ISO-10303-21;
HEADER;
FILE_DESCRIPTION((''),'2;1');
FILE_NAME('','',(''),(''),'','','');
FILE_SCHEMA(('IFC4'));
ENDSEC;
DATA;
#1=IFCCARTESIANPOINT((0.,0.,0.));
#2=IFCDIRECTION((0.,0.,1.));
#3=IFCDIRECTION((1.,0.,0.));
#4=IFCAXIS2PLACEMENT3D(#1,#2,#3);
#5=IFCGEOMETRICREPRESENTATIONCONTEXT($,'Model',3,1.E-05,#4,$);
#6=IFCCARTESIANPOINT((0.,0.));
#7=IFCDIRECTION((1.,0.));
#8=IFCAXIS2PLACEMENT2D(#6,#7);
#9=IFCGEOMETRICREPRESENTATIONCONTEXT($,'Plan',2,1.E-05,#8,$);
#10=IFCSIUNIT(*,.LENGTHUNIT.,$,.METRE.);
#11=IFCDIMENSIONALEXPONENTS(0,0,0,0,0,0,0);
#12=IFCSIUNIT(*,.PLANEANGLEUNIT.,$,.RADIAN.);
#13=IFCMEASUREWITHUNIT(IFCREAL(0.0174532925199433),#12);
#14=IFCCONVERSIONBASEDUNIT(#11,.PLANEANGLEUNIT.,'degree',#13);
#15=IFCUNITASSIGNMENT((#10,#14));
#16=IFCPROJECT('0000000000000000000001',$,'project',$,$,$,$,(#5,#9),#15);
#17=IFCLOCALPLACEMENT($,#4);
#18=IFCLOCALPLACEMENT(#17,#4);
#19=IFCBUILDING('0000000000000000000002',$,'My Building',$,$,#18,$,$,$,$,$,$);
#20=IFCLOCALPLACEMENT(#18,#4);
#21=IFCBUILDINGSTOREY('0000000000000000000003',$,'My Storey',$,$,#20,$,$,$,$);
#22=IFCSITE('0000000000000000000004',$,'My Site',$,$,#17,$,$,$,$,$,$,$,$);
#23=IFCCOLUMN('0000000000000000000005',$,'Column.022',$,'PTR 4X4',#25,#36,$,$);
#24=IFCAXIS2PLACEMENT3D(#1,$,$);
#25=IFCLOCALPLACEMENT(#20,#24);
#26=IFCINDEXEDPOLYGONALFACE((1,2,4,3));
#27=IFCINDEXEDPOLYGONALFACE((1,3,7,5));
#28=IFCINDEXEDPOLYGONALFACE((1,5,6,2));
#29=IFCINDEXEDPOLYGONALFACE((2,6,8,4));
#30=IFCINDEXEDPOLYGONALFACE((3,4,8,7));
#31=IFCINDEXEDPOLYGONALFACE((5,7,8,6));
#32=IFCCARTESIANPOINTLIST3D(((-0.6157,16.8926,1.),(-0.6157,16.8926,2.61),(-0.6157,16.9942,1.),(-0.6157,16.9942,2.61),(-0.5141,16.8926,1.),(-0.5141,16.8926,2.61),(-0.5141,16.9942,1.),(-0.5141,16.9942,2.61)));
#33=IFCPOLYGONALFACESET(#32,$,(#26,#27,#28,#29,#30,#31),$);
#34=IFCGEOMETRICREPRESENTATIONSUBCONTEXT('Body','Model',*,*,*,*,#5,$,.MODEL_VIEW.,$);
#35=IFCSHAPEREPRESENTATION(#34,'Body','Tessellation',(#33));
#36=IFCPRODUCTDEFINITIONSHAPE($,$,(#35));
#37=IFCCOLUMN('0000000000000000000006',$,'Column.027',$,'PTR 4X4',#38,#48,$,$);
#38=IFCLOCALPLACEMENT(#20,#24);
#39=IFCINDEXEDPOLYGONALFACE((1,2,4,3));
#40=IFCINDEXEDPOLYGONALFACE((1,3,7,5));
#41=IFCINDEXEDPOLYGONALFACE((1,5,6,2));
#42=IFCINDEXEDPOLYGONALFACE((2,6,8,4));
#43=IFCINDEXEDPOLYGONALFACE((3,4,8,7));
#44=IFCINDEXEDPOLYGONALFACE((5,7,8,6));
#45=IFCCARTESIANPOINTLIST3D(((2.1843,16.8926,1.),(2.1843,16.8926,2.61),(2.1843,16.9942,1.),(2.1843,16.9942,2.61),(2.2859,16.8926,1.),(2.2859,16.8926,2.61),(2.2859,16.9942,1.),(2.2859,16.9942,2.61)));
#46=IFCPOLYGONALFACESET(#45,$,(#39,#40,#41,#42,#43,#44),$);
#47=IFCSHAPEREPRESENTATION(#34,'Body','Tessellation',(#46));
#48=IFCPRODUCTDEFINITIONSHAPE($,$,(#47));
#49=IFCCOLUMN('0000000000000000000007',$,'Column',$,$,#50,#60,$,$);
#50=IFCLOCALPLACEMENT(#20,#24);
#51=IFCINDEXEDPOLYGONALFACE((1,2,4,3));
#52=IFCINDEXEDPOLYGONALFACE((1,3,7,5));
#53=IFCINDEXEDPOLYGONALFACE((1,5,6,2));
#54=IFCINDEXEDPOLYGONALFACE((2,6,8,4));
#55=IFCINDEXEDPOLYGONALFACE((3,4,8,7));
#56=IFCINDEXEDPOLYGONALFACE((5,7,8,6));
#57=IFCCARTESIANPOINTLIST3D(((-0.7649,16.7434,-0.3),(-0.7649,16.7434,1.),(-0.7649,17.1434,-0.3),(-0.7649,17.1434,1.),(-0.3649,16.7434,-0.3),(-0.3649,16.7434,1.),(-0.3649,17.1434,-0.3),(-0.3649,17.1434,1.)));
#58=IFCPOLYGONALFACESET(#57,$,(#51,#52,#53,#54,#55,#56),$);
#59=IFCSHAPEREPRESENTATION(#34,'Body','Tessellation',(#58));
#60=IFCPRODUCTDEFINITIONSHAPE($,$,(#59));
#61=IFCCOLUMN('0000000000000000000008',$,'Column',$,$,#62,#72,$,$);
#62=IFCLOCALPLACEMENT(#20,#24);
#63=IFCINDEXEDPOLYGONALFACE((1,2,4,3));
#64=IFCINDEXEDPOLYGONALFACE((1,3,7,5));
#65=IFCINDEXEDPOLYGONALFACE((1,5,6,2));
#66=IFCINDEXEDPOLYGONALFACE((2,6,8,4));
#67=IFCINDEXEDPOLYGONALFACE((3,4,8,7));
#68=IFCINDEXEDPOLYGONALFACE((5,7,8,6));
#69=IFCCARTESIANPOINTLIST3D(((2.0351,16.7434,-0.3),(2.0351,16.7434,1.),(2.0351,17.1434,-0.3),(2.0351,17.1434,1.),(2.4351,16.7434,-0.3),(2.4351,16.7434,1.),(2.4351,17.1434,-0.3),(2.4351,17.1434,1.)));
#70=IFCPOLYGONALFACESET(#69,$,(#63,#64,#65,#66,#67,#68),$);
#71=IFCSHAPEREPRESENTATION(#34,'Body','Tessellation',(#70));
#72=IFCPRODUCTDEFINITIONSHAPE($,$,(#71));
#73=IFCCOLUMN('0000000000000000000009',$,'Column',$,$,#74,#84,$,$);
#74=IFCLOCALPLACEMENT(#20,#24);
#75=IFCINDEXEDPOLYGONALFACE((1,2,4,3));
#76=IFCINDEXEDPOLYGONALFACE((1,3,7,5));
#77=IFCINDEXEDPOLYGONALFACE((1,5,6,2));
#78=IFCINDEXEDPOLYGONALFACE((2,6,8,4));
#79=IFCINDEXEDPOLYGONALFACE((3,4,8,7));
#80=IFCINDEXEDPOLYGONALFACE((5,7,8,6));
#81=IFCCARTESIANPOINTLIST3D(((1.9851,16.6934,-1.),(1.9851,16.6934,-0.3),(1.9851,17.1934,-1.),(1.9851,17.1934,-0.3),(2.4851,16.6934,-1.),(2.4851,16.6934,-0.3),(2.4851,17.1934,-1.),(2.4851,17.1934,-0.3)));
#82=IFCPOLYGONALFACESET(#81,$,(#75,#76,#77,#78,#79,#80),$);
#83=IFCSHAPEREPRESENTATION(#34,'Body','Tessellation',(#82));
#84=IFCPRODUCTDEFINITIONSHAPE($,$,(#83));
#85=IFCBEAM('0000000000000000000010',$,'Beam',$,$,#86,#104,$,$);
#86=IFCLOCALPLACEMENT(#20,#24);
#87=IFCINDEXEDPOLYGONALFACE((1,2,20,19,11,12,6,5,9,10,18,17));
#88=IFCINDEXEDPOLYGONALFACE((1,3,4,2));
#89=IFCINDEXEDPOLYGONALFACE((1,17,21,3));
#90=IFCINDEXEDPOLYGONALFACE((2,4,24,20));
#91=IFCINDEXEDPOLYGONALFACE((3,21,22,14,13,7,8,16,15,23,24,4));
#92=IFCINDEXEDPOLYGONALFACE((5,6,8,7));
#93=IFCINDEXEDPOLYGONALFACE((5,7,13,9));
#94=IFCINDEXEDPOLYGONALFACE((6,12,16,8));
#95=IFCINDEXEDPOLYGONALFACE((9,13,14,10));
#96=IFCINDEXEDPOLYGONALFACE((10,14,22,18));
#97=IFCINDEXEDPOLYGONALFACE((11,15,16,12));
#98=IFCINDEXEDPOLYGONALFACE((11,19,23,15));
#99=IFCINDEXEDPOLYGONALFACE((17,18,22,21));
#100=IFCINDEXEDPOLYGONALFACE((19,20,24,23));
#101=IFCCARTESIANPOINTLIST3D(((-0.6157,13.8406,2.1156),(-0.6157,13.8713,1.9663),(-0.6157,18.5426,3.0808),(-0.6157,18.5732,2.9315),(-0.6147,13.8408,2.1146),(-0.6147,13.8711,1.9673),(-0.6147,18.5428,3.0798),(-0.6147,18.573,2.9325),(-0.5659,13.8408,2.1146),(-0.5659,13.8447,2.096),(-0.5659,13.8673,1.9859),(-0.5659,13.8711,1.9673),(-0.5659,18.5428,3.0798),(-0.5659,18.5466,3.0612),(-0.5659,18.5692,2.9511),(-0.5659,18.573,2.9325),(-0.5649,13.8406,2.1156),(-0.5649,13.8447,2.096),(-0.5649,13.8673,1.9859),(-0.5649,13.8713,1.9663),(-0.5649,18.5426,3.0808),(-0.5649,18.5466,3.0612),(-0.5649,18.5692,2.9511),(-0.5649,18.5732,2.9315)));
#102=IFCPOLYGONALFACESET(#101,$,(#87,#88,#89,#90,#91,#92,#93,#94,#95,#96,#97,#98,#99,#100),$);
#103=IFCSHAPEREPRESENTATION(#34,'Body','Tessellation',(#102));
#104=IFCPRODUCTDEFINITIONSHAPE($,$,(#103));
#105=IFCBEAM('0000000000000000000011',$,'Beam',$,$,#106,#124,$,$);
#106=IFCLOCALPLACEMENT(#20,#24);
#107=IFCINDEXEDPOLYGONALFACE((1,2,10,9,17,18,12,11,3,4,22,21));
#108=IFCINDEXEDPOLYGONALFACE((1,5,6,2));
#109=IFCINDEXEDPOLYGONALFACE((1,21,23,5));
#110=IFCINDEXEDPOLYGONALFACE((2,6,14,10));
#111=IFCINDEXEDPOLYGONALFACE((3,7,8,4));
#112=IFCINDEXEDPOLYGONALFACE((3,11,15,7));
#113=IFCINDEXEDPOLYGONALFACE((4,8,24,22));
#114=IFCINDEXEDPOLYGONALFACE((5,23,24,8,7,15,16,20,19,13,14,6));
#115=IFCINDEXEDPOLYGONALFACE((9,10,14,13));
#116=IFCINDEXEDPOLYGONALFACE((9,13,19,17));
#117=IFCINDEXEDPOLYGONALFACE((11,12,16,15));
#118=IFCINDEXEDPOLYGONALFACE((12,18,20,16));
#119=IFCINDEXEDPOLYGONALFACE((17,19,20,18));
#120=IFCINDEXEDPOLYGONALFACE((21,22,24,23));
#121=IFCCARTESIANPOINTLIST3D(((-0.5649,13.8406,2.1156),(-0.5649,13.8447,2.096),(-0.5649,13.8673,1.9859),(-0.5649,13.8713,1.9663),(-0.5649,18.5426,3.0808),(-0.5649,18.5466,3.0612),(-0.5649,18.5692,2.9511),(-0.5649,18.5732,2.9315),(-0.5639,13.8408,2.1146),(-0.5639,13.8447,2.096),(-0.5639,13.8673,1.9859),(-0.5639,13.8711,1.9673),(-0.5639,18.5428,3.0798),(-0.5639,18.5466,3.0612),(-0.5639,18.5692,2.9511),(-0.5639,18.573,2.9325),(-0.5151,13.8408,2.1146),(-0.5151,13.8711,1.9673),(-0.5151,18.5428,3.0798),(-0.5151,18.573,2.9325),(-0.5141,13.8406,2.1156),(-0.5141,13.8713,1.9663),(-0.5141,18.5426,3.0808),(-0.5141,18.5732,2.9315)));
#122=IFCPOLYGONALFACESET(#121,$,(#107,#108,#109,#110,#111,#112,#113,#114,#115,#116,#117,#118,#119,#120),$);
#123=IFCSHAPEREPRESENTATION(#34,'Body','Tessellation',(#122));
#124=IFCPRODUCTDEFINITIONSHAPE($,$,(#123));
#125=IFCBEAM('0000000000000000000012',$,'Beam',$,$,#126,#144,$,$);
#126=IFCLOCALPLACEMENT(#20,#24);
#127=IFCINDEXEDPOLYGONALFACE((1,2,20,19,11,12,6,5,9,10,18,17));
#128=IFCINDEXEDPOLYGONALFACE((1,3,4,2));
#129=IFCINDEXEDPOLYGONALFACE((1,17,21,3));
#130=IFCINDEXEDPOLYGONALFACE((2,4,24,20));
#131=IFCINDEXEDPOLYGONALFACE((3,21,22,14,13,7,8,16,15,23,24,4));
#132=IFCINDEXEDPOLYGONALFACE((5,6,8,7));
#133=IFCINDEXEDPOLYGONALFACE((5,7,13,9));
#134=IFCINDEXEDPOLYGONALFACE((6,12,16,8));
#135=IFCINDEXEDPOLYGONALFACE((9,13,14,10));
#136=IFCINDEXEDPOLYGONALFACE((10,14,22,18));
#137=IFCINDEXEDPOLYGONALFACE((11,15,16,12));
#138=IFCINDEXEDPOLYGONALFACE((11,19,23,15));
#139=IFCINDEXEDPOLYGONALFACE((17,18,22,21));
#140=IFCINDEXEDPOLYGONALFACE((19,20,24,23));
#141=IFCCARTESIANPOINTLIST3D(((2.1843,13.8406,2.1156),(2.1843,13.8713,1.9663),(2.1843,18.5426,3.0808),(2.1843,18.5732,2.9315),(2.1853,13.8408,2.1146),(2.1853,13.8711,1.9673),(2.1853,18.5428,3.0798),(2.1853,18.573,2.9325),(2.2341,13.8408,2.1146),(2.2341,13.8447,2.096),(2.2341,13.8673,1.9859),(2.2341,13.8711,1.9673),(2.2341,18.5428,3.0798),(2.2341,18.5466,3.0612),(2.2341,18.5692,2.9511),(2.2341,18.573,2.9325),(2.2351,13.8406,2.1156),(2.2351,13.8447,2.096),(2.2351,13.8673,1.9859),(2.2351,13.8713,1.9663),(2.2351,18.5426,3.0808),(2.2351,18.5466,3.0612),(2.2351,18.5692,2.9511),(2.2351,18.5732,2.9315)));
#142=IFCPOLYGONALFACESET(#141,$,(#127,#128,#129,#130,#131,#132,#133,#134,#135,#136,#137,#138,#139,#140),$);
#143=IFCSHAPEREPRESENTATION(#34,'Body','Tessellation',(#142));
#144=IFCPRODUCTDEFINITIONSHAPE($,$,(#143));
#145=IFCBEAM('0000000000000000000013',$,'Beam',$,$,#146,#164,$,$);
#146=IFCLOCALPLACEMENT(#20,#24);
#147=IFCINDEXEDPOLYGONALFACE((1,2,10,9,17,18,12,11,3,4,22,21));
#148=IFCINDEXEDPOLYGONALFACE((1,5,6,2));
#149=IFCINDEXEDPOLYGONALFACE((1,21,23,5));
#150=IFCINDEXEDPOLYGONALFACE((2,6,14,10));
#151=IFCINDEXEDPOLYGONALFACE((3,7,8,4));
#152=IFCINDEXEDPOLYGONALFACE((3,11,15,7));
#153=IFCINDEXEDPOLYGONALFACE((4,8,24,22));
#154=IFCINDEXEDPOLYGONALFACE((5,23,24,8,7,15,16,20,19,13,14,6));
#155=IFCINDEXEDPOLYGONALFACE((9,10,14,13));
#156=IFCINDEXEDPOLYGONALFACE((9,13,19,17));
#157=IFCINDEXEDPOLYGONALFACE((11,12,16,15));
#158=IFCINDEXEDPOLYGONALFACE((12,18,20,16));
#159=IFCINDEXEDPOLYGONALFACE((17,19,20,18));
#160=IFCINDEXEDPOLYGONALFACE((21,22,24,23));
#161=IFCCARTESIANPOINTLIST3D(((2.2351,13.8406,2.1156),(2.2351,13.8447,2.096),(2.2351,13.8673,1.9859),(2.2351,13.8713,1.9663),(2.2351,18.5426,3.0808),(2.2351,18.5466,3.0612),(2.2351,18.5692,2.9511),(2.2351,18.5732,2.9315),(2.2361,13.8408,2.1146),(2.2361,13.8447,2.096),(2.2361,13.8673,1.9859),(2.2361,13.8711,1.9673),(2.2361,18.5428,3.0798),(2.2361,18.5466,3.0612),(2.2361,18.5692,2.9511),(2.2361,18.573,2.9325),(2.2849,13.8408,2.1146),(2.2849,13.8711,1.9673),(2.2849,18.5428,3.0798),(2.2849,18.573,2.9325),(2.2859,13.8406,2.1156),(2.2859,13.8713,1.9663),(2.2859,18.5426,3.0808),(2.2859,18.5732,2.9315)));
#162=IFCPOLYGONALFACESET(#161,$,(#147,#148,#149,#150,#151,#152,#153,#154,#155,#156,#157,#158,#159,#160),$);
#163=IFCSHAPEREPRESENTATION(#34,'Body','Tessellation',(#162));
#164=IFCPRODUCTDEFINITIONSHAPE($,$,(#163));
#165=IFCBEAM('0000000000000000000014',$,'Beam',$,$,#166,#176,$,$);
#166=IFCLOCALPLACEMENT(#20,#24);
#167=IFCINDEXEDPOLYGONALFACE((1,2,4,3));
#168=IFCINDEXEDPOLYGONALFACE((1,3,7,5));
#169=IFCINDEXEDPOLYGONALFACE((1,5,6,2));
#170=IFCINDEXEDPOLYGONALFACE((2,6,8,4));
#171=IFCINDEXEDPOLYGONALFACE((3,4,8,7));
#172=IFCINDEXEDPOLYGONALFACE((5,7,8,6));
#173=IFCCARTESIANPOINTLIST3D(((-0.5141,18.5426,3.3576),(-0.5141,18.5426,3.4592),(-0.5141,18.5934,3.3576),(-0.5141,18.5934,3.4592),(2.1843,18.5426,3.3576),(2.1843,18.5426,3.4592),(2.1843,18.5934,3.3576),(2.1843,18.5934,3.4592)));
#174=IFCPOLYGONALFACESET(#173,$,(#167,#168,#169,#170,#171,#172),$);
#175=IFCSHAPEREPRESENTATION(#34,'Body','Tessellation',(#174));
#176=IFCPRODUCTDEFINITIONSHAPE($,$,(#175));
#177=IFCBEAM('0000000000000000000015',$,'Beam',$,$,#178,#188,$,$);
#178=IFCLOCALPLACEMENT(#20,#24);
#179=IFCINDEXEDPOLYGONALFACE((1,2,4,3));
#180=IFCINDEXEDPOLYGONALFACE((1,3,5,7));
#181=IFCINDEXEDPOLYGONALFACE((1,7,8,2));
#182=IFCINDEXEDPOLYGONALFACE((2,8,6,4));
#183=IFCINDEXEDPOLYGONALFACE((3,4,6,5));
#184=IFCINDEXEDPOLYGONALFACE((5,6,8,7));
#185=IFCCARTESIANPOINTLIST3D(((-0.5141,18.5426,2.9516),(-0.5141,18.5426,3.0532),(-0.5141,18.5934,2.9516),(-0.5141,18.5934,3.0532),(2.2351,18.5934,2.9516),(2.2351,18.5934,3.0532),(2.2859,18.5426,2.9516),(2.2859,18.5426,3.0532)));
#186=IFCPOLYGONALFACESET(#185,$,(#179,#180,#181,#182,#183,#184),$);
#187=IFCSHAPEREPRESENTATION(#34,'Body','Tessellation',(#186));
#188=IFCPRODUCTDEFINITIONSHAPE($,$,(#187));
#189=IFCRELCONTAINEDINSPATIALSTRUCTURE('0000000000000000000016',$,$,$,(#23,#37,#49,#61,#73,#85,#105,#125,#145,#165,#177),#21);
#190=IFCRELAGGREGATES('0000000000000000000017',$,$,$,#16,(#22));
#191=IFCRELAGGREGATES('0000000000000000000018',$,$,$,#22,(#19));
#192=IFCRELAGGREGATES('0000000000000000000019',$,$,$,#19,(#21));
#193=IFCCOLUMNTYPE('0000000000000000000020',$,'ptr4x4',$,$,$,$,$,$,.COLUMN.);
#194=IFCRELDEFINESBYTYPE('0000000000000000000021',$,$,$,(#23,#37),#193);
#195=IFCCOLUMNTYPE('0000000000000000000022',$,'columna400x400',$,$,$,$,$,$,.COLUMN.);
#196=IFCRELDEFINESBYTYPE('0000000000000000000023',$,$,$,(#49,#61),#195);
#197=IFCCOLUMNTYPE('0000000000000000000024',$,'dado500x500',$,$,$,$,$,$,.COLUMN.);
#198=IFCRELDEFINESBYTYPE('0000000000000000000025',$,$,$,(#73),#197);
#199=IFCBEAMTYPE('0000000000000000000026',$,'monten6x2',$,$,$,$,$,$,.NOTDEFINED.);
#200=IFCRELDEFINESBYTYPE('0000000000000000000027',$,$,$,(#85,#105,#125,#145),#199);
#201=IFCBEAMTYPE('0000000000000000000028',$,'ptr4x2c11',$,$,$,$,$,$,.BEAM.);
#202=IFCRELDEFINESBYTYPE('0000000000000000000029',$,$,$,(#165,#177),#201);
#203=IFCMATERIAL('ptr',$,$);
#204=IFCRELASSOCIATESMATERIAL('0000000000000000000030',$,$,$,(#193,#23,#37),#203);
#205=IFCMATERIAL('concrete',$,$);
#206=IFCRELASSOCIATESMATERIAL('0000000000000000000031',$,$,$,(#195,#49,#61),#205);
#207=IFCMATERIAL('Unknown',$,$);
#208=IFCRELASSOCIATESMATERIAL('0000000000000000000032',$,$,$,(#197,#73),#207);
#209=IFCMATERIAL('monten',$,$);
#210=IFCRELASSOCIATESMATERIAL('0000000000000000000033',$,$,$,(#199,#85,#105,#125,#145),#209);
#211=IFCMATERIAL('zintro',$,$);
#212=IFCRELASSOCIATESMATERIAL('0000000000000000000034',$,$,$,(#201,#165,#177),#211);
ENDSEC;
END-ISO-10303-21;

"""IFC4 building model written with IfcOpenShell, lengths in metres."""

from ifc_helpers import new_model, entity, si_unit, converted_unit, frame, origin_with_axes, origin_2d_with_axis, place, context, subcontext, project, spatial, rectangle, c_section, extrude, clip, halfspace, material, material_profile, profile_set, profile_usage, type_object, element, save


model = new_model("IFC4")

# Units and contexts
model_context = context("Model", 3, precision=1e-05, world=origin_with_axes())
plan_context = context("Plan", 2, precision=1e-05, world=origin_2d_with_axis())
body_context = subcontext(model_context, "Body", "Model", "MODEL_VIEW")
ifc_project = project(units=[si_unit("LENGTHUNIT", "METRE"), converted_unit("PLANEANGLEUNIT", "degree", entity("IfcReal", 0.0174532925199433), si_unit("PLANEANGLEUNIT", "RADIAN"), dimensions=[0, 0, 0, 0, 0, 0, 0])], contexts=[model_context, plan_context])

# Site, building, storey
site_placement = place(None, origin_with_axes())
site = spatial("IfcSite", under=ifc_project, at=site_placement, Name="My Site")
building_placement = place(site_placement, origin_with_axes())
building = spatial("IfcBuilding", under=site, at=building_placement, Name="My Building")
storey_placement = place(building_placement, origin_with_axes())
storey = spatial("IfcBuildingStorey", under=building, at=storey_placement, Name="My Storey")

# Columns
ifc_material_1 = material(Name="ptr")
ifc_material_profile_1 = material_profile(ifc_material_1, rectangle(XDim=0.1016, YDim=0.1016))
ifc_profile_set_1 = profile_set([ifc_material_profile_1])
ifc_profile_usage_1 = profile_usage(ifc_profile_set_1, cardinal=5)
column_type_1 = type_object("IfcColumnType", Name="ptr4x4", PredefinedType="COLUMN", material=ifc_profile_set_1)
column_1_placement = place(storey_placement, frame((-0.5649, 16.9434, 1.0), z_axis=(0.0, 0.0, 1.0), x_axis=(1.0, 0.0, 0.0)))
element("IfcColumn", 1, at=column_1_placement, inside=storey, type_object=column_type_1, material=ifc_profile_usage_1, Name="Column.022", ObjectType="PTR 4X4", context=body_context, shape_type="SweptSolid", body=[
    extrude(rectangle(XDim=0.1016, YDim=0.1016), origin_with_axes(), (0.0, 0.0, 1.0), 1.61),
])
ifc_profile_usage_2 = profile_usage(ifc_profile_set_1, cardinal=5)
column_2_placement = place(storey_placement, frame((2.2351, 16.9434, 1.0), z_axis=(0.0, 0.0, 1.0), x_axis=(1.0, 0.0, 0.0)))
element("IfcColumn", 2, at=column_2_placement, inside=storey, type_object=column_type_1, material=ifc_profile_usage_2, Name="Column.027", ObjectType="PTR 4X4", context=body_context, shape_type="SweptSolid", body=[
    extrude(rectangle(XDim=0.1016, YDim=0.1016), origin_with_axes(), (0.0, 0.0, 1.0), 1.61),
])
ifc_material_2 = material(Name="concrete")
ifc_material_profile_2 = material_profile(ifc_material_2, rectangle(XDim=0.4, YDim=0.4))
ifc_profile_set_2 = profile_set([ifc_material_profile_2], Name="concrete")
ifc_profile_usage_3 = profile_usage(ifc_profile_set_2)
column_type_2 = type_object("IfcColumnType", Name="columna400x400", PredefinedType="COLUMN", material=ifc_profile_set_2)
column_3_placement = place(storey_placement, frame((-0.5649, 16.9434, -0.3), z_axis=(0.0, 0.0, 1.0), x_axis=(1.0, 0.0, 0.0)))
element("IfcColumn", 3, at=column_3_placement, inside=storey, type_object=column_type_2, material=ifc_profile_usage_3, Name="Column", context=body_context, shape_type="SweptSolid", body=[
    extrude(rectangle(XDim=0.4, YDim=0.4), origin_with_axes(), (0.0, 0.0, 1.0), 1.3),
])
ifc_profile_usage_4 = profile_usage(ifc_profile_set_2)
column_4_placement = place(storey_placement, frame((2.2351, 16.9434, -0.3), z_axis=(0.0, 0.0, 1.0), x_axis=(1.0, 0.0, 0.0)))
element("IfcColumn", 4, at=column_4_placement, inside=storey, type_object=column_type_2, material=ifc_profile_usage_4, Name="Column", context=body_context, shape_type="SweptSolid", body=[
    extrude(rectangle(XDim=0.4, YDim=0.4), origin_with_axes(), (0.0, 0.0, 1.0), 1.3),
])
ifc_material_3 = material(Name="Unknown")
ifc_material_profile_3 = material_profile(ifc_material_3, rectangle(XDim=0.5, YDim=0.5))
ifc_profile_set_3 = profile_set([ifc_material_profile_3], Name="concrete")
ifc_profile_usage_5 = profile_usage(ifc_profile_set_3)
column_type_3 = type_object("IfcColumnType", Name="dado500x500", PredefinedType="COLUMN", material=ifc_profile_set_3)
column_5_placement = place(storey_placement, frame((2.2351, 16.9434, -1.0), z_axis=(0.0, 0.0, 1.0), x_axis=(1.0, 0.0, 0.0)))
element("IfcColumn", 5, at=column_5_placement, inside=storey, type_object=column_type_3, material=ifc_profile_usage_5, Name="Column", context=body_context, shape_type="SweptSolid", body=[
    extrude(rectangle(XDim=0.5, YDim=0.5), origin_with_axes(), (0.0, 0.0, 1.0), 0.7),
])

# Beams
ifc_material_4 = material(Name="monten")
ifc_material_profile_4 = material_profile(ifc_material_4, c_section(Depth=0.1524, Width=0.0508, WallThickness=0.001, Girth=0.02))
ifc_profile_set_4 = profile_set([ifc_material_profile_4])
ifc_profile_usage_6 = profile_usage(ifc_profile_set_4, cardinal=5)
beam_type_1 = type_object("IfcBeamType", Name="monten6x2", PredefinedType="NOTDEFINED", material=ifc_profile_set_4)
beam_1_placement = place(storey_placement, frame((-0.5903, 18.5579, 3.0061), z_axis=(0.0, -0.979575, -0.201078), x_axis=(1.0, 0.0, 0.0)))
element("IfcBeam", 6, at=beam_1_placement, inside=storey, type_object=beam_type_1, material=ifc_profile_usage_6, Name="Beam", context=body_context, shape_type="SweptSolid", body=[
    extrude(c_section(Depth=0.1524, Width=0.0508, WallThickness=0.001, Girth=0.02), origin_with_axes(), (0.0, 0.0, 1.0), 4.8),
])
ifc_profile_usage_7 = profile_usage(ifc_profile_set_4, cardinal=5)
beam_2_placement = place(storey_placement, frame((-0.5395, 18.5579, 3.0061), z_axis=(0.0, -0.979575, -0.201078), x_axis=(-1.0, 0.0, 0.000001)))
element("IfcBeam", 7, at=beam_2_placement, inside=storey, type_object=beam_type_1, material=ifc_profile_usage_7, Name="Beam", context=body_context, shape_type="SweptSolid", body=[
    extrude(c_section(Depth=0.1524, Width=0.0508, WallThickness=0.001, Girth=0.02), origin_with_axes(), (0.0, 0.0, 1.0), 4.8),
])
ifc_profile_usage_8 = profile_usage(ifc_profile_set_4, cardinal=5)
beam_3_placement = place(storey_placement, frame((2.2097, 18.5579, 3.0061), z_axis=(0.0, -0.979575, -0.201078), x_axis=(1.0, 0.0, 0.0)))
element("IfcBeam", 8, at=beam_3_placement, inside=storey, type_object=beam_type_1, material=ifc_profile_usage_8, Name="Beam", context=body_context, shape_type="SweptSolid", body=[
    extrude(c_section(Depth=0.1524, Width=0.0508, WallThickness=0.001, Girth=0.02), origin_with_axes(), (0.0, 0.0, 1.0), 4.8),
])
ifc_profile_usage_9 = profile_usage(ifc_profile_set_4, cardinal=5)
beam_4_placement = place(storey_placement, frame((2.2605, 18.5579, 3.0061), z_axis=(0.0, -0.979575, -0.201078), x_axis=(-1.0, 0.0, 0.000001)))
element("IfcBeam", 9, at=beam_4_placement, inside=storey, type_object=beam_type_1, material=ifc_profile_usage_9, Name="Beam", context=body_context, shape_type="SweptSolid", body=[
    extrude(c_section(Depth=0.1524, Width=0.0508, WallThickness=0.001, Girth=0.02), origin_with_axes(), (0.0, 0.0, 1.0), 4.8),
])
ifc_material_5 = material(Name="zintro")
ifc_material_profile_5 = material_profile(ifc_material_5, rectangle(XDim=0.0508, YDim=0.1016))
ifc_profile_set_5 = profile_set([ifc_material_profile_5])
ifc_profile_usage_10 = profile_usage(ifc_profile_set_5)
beam_type_2 = type_object("IfcBeamType", Name="ptr4x2c11", PredefinedType="BEAM", material=ifc_profile_set_5)
beam_5_placement = place(storey_placement, frame((-0.5141, 18.568, 3.4084), z_axis=(1.0, 0.0, 0.0), x_axis=(0.0, 1.0, 0.0)))
element("IfcBeam", 10, at=beam_5_placement, inside=storey, type_object=beam_type_2, material=ifc_profile_usage_10, Name="Beam", context=body_context, shape_type="SweptSolid", body=[
    extrude(rectangle(XDim=0.0508, YDim=0.1016), origin_with_axes(), (0.0, 0.0, 1.0), 2.6984),
])
ifc_profile_usage_11 = profile_usage(ifc_profile_set_5)
beam_6_placement = place(storey_placement, frame((-0.5141, 18.568, 3.0024), z_axis=(1.0, 0.0, 0.0), x_axis=(0.0, 1.0, 0.0)))
element("IfcBeam", 11, at=beam_6_placement, inside=storey, type_object=beam_type_2, material=ifc_profile_usage_11, Name="Beam", context=body_context, shape_type="Clipping", body=[
    clip(extrude(rectangle(XDim=0.0508, YDim=0.1016), origin_with_axes(), (0.0, 0.0, 1.0), 2.8), halfspace(frame((-0.0254, -3.0024, 2.8), z_axis=(0.707103, 0.0, 0.70711), x_axis=(0.70711, 0.0, -0.707103)), False)),
])

save(model, "model.ifc")
